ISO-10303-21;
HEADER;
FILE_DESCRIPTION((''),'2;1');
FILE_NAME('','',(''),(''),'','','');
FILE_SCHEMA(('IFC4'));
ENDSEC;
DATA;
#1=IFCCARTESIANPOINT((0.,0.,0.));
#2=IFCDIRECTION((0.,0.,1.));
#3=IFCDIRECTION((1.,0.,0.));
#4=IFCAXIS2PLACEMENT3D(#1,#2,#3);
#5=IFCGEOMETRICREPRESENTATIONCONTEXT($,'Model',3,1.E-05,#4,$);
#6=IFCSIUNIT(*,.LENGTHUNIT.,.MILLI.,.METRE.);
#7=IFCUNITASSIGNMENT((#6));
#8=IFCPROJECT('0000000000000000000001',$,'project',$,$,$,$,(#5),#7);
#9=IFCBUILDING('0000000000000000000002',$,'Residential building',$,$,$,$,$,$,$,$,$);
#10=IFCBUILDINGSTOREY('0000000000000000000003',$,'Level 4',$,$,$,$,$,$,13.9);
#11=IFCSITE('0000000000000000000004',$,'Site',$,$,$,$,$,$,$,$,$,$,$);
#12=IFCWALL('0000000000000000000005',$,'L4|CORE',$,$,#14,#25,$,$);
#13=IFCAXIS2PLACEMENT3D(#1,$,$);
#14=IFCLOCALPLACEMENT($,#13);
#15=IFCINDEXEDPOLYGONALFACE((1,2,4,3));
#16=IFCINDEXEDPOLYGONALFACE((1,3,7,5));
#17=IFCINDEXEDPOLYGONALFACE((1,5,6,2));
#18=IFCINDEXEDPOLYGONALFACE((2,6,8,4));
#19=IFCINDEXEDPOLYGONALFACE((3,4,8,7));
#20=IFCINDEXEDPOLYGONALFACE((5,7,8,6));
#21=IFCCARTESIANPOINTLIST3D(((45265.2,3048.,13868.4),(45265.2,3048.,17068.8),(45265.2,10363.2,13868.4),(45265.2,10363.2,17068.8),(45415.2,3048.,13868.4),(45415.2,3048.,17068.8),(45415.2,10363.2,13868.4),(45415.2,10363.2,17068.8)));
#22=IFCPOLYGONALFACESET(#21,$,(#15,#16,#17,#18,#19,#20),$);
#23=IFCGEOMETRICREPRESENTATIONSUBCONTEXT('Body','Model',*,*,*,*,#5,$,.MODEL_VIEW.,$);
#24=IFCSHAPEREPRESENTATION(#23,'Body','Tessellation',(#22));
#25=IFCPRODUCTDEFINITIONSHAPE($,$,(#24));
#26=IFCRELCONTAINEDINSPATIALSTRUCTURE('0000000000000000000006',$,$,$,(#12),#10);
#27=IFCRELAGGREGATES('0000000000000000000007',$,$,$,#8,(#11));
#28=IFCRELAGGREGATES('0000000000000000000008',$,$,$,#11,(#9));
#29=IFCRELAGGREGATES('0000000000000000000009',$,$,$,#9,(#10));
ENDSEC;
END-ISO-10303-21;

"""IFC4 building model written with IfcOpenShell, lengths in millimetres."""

from ifc_helpers import new_model, si_unit, frame, origin_with_axes, place, context, subcontext, project, spatial, indexed_curve, outline, extrude, element, save


model = new_model("IFC4")

# Units and contexts
model_context = context("Model", 3, precision=1e-05, world=origin_with_axes())
body_context = subcontext(model_context, "Body", "Model", "MODEL_VIEW")
ifc_project = project(units=[si_unit("LENGTHUNIT", "METRE", prefix="MILLI")], contexts=[model_context])

# Site, building, storey
site = spatial("IfcSite", under=ifc_project, Name="Site")
building = spatial("IfcBuilding", under=site, Name="Residential building")
storey = spatial("IfcBuildingStorey", under=building, Name="Level 4", Elevation=13.9)

# Wall
for number, where, z_axis, x_axis, name in (
    (1, (45415.2, 3048.0, 13868.4), (0.0, 0.0, 1.0), (0.0, 1.0, 0.0), "L4|CORE"),
):
    element("IfcWall", number, at=place(None, frame(where, z_axis=z_axis, x_axis=x_axis)), inside=storey, Name=name, context=body_context, shape_type="SweptSolid", body=[
        extrude(outline(indexed_curve([(0.0, 0.0), (0.0, 150.0), (7315.2, 150.0), (7315.2, 0.0), (0.0, 0.0)], self_intersect=False)), origin_with_axes(), (0.0, 0.0, 1.0), 3200.4),
    ])

save(model, "model.ifc")
